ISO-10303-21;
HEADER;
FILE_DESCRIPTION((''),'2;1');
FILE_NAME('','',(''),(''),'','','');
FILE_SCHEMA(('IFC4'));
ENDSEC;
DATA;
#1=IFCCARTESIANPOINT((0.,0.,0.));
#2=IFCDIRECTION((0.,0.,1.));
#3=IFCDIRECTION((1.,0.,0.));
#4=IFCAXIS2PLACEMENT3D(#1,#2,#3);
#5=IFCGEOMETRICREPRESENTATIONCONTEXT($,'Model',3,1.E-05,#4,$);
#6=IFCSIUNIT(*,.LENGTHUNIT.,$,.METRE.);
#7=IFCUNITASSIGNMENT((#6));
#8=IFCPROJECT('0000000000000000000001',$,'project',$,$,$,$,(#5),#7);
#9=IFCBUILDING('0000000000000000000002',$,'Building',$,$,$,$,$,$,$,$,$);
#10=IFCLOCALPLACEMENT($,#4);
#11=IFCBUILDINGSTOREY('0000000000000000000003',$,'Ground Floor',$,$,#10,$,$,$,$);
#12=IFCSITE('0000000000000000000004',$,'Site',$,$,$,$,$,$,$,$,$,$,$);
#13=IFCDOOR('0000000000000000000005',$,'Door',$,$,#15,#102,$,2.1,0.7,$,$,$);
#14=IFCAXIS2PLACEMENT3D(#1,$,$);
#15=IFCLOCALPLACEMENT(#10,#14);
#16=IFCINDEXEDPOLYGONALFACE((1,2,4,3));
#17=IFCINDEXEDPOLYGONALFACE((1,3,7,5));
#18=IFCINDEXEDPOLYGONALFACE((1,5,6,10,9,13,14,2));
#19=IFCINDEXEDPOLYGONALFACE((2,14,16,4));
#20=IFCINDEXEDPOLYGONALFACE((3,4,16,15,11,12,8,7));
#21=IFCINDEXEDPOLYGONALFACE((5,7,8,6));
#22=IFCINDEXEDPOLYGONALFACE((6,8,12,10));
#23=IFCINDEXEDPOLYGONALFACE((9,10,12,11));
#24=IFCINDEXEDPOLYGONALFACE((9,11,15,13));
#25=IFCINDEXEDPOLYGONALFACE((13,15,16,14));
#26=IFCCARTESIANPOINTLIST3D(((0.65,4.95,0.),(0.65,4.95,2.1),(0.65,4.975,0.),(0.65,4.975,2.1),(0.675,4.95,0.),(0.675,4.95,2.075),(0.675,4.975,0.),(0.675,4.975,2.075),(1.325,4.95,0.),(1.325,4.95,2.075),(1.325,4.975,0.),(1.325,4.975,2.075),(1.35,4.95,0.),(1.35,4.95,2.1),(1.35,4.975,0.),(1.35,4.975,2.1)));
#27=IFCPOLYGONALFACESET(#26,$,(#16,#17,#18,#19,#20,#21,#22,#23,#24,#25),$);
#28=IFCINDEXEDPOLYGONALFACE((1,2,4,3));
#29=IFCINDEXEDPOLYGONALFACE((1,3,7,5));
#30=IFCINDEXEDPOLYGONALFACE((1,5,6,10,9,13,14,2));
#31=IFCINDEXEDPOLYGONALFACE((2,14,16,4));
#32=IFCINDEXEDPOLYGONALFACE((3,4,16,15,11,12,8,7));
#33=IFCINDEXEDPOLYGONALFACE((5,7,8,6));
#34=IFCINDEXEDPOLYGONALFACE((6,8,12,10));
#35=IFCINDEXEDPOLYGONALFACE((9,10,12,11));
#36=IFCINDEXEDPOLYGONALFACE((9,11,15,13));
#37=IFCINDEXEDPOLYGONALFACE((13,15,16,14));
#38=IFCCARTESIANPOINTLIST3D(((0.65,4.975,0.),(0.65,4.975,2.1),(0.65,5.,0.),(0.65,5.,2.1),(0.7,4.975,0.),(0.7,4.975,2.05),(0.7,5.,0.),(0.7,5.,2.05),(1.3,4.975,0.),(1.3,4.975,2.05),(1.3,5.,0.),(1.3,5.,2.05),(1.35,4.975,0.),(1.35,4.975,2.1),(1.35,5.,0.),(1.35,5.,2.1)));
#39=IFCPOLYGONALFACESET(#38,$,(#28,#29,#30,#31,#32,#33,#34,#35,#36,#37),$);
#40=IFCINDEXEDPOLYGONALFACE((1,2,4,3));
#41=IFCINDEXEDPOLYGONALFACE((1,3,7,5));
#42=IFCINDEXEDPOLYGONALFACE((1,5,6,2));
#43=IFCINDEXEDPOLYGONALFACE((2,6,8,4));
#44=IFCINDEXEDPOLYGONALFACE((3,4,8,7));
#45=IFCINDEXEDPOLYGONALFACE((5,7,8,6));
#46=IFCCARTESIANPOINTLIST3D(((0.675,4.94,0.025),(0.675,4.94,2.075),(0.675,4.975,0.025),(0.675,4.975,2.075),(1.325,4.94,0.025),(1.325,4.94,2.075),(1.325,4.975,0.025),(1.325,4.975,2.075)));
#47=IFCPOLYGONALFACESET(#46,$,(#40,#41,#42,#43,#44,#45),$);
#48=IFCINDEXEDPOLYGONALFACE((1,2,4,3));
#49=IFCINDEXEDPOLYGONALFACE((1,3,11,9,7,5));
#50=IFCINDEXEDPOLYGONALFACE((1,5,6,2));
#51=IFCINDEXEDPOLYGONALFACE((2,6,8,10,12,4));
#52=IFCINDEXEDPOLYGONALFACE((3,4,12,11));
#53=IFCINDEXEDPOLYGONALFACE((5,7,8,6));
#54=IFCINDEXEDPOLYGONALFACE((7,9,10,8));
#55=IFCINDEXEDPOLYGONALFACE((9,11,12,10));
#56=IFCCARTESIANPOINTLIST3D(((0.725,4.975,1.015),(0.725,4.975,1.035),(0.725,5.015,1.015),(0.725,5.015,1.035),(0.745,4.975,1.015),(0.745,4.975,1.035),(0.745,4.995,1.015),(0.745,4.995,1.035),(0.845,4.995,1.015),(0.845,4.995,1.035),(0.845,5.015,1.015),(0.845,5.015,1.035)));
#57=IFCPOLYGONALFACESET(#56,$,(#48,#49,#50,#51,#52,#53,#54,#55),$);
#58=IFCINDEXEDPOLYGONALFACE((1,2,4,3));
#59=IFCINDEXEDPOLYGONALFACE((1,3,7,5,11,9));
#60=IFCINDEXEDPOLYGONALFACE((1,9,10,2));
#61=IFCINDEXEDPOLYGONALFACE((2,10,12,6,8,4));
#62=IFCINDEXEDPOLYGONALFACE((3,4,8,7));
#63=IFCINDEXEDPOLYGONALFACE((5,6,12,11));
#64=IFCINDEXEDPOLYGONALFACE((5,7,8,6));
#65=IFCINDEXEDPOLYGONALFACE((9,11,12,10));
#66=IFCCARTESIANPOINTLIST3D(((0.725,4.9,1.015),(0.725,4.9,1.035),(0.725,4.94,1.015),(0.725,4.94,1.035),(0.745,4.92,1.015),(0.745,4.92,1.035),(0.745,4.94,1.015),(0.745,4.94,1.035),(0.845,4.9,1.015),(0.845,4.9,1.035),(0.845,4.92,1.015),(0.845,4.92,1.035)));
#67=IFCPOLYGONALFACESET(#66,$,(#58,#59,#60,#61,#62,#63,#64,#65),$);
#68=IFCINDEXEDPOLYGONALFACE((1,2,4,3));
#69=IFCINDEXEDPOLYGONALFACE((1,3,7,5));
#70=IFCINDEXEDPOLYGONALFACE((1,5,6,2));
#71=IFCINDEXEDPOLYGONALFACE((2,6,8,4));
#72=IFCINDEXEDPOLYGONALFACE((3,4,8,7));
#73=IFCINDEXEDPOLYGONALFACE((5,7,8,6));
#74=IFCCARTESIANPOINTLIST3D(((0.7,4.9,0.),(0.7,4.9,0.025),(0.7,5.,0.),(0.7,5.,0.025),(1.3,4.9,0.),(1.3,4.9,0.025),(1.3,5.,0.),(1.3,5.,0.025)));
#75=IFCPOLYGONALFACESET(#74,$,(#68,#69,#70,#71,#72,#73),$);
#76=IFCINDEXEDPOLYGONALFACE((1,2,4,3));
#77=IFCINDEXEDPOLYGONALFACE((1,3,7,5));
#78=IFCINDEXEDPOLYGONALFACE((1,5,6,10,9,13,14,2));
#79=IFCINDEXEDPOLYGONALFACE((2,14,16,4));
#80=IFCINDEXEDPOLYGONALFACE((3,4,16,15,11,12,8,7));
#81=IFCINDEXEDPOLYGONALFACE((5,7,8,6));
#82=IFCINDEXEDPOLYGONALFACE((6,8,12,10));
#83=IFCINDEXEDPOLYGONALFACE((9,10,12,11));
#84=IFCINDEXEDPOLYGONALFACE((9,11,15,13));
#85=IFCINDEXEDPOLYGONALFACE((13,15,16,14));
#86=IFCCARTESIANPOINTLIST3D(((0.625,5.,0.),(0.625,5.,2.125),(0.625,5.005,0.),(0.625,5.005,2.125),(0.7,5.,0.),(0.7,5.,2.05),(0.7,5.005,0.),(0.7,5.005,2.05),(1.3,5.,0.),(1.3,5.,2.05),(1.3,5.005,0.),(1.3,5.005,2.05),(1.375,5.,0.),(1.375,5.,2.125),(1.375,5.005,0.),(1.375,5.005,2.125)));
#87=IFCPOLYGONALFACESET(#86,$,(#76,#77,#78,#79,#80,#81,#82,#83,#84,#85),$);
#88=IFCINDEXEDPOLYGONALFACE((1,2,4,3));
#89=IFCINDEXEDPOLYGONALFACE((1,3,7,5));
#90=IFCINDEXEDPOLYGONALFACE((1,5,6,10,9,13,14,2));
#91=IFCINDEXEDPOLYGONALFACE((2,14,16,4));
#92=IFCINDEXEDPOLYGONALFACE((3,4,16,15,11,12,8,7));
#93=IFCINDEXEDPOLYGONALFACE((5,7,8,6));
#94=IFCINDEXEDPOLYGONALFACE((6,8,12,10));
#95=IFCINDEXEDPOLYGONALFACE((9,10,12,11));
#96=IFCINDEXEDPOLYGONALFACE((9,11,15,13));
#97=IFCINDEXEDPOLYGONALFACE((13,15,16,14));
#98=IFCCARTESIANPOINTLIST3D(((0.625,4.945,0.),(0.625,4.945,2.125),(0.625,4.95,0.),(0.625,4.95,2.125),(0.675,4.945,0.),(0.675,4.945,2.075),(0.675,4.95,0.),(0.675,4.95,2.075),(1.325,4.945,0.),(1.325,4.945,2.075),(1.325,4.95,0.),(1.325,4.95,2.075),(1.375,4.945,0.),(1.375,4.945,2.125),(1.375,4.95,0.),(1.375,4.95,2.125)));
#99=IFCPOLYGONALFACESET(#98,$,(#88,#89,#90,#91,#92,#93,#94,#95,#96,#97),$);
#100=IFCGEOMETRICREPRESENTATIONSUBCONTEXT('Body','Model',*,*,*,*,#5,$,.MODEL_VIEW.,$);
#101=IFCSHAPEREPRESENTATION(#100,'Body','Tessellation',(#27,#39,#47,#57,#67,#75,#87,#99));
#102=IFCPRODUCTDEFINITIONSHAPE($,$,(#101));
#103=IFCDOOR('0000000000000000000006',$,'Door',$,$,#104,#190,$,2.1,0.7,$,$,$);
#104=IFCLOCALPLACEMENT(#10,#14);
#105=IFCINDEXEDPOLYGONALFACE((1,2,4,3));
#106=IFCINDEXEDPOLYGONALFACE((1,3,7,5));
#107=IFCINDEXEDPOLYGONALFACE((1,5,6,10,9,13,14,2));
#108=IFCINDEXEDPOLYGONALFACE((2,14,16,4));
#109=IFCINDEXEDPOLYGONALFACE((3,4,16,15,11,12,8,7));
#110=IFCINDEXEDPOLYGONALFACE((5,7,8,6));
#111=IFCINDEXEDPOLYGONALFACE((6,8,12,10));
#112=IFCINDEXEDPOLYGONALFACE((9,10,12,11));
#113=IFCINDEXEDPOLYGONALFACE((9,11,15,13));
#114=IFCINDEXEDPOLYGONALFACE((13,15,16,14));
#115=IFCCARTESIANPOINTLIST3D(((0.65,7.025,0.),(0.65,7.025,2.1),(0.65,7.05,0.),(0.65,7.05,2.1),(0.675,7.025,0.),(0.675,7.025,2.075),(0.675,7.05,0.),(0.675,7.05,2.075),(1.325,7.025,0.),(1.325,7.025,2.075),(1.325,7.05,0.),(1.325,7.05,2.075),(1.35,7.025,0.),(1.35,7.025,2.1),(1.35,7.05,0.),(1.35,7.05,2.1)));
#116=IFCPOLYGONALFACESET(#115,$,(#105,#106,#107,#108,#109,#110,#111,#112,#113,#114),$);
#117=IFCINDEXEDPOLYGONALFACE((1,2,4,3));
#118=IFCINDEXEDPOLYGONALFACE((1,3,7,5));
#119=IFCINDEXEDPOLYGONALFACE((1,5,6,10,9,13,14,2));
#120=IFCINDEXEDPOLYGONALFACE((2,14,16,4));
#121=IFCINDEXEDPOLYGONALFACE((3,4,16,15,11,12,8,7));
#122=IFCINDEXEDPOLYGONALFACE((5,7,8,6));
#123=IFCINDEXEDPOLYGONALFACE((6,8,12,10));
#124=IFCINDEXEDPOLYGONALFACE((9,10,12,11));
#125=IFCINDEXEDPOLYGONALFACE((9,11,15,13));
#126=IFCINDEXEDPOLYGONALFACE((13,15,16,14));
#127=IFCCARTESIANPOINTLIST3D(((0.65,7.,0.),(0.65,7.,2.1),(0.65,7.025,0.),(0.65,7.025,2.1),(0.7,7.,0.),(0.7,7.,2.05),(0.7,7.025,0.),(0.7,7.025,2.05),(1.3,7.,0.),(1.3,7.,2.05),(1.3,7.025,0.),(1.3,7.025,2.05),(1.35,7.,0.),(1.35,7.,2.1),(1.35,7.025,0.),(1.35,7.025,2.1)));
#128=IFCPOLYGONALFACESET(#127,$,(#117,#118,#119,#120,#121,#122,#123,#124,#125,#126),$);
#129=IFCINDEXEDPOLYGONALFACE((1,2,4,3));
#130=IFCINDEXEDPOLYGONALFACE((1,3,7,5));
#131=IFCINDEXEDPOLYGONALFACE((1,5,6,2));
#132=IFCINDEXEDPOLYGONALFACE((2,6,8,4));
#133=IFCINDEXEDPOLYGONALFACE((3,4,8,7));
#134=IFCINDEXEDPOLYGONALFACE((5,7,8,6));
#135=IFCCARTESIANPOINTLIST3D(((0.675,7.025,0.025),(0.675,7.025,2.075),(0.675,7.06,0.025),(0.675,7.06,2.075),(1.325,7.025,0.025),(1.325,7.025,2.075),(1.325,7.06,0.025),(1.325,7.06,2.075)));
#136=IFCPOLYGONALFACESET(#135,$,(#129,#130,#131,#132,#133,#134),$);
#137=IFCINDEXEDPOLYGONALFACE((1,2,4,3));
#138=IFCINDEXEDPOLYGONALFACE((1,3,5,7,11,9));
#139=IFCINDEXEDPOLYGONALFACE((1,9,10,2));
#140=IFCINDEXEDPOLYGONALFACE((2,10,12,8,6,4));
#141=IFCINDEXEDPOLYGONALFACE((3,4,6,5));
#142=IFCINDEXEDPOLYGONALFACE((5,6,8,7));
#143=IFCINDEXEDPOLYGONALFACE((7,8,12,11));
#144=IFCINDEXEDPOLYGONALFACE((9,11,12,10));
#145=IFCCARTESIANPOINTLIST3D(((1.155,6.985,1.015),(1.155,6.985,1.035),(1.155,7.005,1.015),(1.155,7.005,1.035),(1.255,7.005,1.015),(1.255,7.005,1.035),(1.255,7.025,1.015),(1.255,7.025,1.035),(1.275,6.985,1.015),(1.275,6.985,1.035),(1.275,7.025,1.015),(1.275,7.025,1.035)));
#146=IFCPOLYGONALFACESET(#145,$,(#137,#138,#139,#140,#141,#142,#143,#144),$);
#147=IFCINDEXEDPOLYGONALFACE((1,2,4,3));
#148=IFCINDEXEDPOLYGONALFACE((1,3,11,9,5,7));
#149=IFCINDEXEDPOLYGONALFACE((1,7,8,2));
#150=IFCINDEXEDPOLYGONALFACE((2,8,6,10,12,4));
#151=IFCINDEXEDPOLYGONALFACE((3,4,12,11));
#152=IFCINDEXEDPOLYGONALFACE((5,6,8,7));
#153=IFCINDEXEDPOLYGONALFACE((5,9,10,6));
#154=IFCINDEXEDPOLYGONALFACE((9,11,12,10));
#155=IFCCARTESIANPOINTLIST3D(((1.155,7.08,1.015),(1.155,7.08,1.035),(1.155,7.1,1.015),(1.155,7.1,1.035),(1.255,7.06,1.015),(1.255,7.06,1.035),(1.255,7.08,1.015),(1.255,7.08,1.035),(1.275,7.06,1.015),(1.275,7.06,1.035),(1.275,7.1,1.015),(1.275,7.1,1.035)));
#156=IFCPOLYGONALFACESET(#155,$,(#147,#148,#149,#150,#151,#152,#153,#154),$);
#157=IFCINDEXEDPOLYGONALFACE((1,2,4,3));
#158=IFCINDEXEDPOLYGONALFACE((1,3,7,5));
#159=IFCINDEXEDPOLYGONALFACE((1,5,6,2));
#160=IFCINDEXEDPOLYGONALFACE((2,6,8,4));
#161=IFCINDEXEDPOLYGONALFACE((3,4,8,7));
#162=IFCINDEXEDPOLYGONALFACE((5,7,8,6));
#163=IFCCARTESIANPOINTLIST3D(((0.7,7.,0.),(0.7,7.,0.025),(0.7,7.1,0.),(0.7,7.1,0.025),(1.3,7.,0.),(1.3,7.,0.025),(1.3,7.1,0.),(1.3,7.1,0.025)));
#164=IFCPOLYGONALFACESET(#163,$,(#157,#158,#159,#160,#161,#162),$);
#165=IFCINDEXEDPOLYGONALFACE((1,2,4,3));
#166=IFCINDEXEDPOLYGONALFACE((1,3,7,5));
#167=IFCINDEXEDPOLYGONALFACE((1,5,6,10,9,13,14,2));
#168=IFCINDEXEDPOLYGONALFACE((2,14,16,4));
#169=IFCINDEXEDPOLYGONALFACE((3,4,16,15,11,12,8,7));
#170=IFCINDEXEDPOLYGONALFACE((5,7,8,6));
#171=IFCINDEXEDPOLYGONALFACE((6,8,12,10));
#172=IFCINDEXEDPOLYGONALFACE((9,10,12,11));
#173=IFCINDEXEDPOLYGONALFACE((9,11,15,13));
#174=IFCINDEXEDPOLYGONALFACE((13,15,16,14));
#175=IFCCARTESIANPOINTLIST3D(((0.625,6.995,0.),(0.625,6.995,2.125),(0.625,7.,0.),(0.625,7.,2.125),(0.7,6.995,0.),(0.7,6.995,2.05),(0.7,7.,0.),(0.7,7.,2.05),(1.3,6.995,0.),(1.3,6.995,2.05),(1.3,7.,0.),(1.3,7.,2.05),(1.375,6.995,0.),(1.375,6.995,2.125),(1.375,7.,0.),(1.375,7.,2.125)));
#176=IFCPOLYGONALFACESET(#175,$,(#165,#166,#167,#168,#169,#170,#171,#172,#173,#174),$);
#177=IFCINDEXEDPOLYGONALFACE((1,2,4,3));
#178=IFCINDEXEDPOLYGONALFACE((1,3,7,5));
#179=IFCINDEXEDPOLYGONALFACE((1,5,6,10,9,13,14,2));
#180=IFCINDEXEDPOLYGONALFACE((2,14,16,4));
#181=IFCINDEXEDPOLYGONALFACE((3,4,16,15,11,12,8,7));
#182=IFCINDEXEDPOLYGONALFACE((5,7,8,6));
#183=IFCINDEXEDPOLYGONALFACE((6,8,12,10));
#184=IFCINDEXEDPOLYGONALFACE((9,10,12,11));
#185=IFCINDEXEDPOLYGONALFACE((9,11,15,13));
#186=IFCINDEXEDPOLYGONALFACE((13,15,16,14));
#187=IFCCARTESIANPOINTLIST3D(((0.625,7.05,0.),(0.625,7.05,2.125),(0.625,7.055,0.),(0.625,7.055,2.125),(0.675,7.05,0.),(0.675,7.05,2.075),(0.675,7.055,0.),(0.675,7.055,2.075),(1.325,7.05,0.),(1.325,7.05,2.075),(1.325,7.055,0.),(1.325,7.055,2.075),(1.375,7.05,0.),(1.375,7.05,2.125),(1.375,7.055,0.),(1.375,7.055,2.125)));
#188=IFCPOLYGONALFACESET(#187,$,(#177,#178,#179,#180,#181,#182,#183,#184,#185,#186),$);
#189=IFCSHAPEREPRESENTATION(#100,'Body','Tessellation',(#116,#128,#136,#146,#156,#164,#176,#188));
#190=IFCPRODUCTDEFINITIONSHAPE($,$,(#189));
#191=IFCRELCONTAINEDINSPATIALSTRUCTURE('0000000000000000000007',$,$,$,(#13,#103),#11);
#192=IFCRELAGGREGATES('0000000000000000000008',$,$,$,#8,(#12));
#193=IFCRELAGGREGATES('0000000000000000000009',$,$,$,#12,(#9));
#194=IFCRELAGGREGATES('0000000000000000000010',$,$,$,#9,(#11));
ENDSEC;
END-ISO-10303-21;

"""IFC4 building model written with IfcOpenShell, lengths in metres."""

from ifc_helpers import new_model, si_unit, frame, origin_with_axes, place, context, subcontext, project, spatial, line, indexed_curve, outline, extrude, element, save


model = new_model("IFC4")

# Units and contexts
model_context = context("Model", 3, precision=1e-05, world=origin_with_axes())
body_context = subcontext(model_context, "Body", "Model", "MODEL_VIEW")
ifc_project = project(units=[si_unit("LENGTHUNIT", "METRE")], contexts=[model_context])

# Site, building, storey
site = spatial("IfcSite", under=ifc_project, Name="Site")
building = spatial("IfcBuilding", under=site, Name="Building")
storey_placement = place(None, origin_with_axes())
storey = spatial("IfcBuildingStorey", under=building, at=storey_placement, Name="Ground Floor")

# Doors
door_1_placement = place(storey_placement, frame((1.35, 5.0, 0.0), z_axis=(0.0, 0.0, 1.0), x_axis=(-1.0, 0.0, 0.0)))
element("IfcDoor", 1, at=door_1_placement, inside=storey, Name="Door", OverallHeight=2.1, OverallWidth=0.7, context=body_context, shape_type="SweptSolid", body=[
    extrude(outline(indexed_curve([(0.0, 0.0), (0.0, 2.1), (0.7, 2.1), (0.7, 0.0), (0.675, 0.0), (0.675, 2.075), (0.025, 2.075), (0.025, 0.0)], segments=[line(1, 2, 3, 4, 5, 6, 7, 8, 1)])), frame((0.0, 0.025, 0.0), z_axis=(0.0, -1.0, 0.0), x_axis=(1.0, 0.0, 0.0)), (0.0, 0.0, -1.0), 0.025),
    extrude(outline(indexed_curve([(0.0, 0.0), (0.0, 2.1), (0.7, 2.1), (0.7, 0.0), (0.65, 0.0), (0.65, 2.05), (0.05, 2.05), (0.05, 0.0)], segments=[line(1, 2, 3, 4, 5, 6, 7, 8, 1)])), frame((0.0, 0.0, 0.0), z_axis=(0.0, -1.0, 0.0), x_axis=(1.0, 0.0, 0.0)), (0.0, 0.0, -1.0), 0.025),
    extrude(outline(indexed_curve([(0.0, 0.0), (0.65, 0.0), (0.65, 0.035), (0.0, 0.035)], segments=[line(1, 2, 3, 4, 1)])), frame((0.025, 0.025, 0.025), z_axis=(0.0, 0.0, 1.0), x_axis=(1.0, 0.0, 0.0)), (0.0, 0.0, 1.0), 2.05),
    extrude(outline(indexed_curve([(0.0, 0.0), (0.0, -0.04), (-0.12, -0.04), (-0.12, -0.02), (-0.02, -0.02), (-0.02, 0.0)], segments=[line(1, 2, 3, 4, 5, 6, 1)])), frame((0.625, 0.025, 1.015), z_axis=(0.0, 0.0, 1.0), x_axis=(1.0, 0.0, 0.0)), (0.0, 0.0, 1.0), 0.02),
    extrude(outline(indexed_curve([(0.0, 0.0), (0.0, 0.04), (-0.12, 0.04), (-0.12, 0.02), (-0.02, 0.02), (-0.02, 0.0)], segments=[line(1, 2, 3, 4, 5, 6, 1)])), frame((0.625, 0.06, 1.015), z_axis=(0.0, 0.0, 1.0), x_axis=(1.0, 0.0, 0.0)), (0.0, 0.0, 1.0), 0.02),
    extrude(outline(indexed_curve([(0.0, 0.0), (0.6, 0.0), (0.6, 0.1), (0.0, 0.1)], segments=[line(1, 2, 3, 4, 1)])), frame((0.05, 0.0, 0.0), z_axis=(0.0, 0.0, 1.0), x_axis=(1.0, 0.0, 0.0)), (0.0, 0.0, 1.0), 0.025),
    extrude(outline(indexed_curve([(0.0, 0.0), (0.0, 2.125), (0.75, 2.125), (0.75, 0.0), (0.675, 0.0), (0.675, 2.05), (0.075, 2.05), (0.075, 0.0)], segments=[line(1, 2, 3, 4, 5, 6, 7, 8, 1)])), frame((-0.025, -0.005, 0.0), z_axis=(0.0, -1.0, 0.0), x_axis=(1.0, 0.0, 0.0)), (0.0, 0.0, -1.0), 0.005),
    extrude(outline(indexed_curve([(0.0, 0.0), (0.0, 2.125), (0.75, 2.125), (0.75, 0.0), (0.7, 0.0), (0.7, 2.075), (0.05, 2.075), (0.05, 0.0)], segments=[line(1, 2, 3, 4, 5, 6, 7, 8, 1)])), frame((-0.025, 0.05, 0.0), z_axis=(0.0, -1.0, 0.0), x_axis=(1.0, 0.0, 0.0)), (0.0, 0.0, -1.0), 0.005),
])
door_2_placement = place(storey_placement, frame((0.65, 7.0, 0.0), z_axis=(0.0, 0.0, 1.0), x_axis=(1.0, 0.0, 0.0)))
element("IfcDoor", 2, at=door_2_placement, inside=storey, Name="Door", OverallHeight=2.1, OverallWidth=0.7, context=body_context, shape_type="SweptSolid", body=[
    extrude(outline(indexed_curve([(0.0, 0.0), (0.0, 2.1), (0.7, 2.1), (0.7, 0.0), (0.675, 0.0), (0.675, 2.075), (0.025, 2.075), (0.025, 0.0)], segments=[line(1, 2, 3, 4, 5, 6, 7, 8, 1)])), frame((0.0, 0.025, 0.0), z_axis=(0.0, -1.0, 0.0), x_axis=(1.0, 0.0, 0.0)), (0.0, 0.0, -1.0), 0.025),
    extrude(outline(indexed_curve([(0.0, 0.0), (0.0, 2.1), (0.7, 2.1), (0.7, 0.0), (0.65, 0.0), (0.65, 2.05), (0.05, 2.05), (0.05, 0.0)], segments=[line(1, 2, 3, 4, 5, 6, 7, 8, 1)])), frame((0.0, 0.0, 0.0), z_axis=(0.0, -1.0, 0.0), x_axis=(1.0, 0.0, 0.0)), (0.0, 0.0, -1.0), 0.025),
    extrude(outline(indexed_curve([(0.0, 0.0), (0.65, 0.0), (0.65, 0.035), (0.0, 0.035)], segments=[line(1, 2, 3, 4, 1)])), frame((0.025, 0.025, 0.025), z_axis=(0.0, 0.0, 1.0), x_axis=(1.0, 0.0, 0.0)), (0.0, 0.0, 1.0), 2.05),
    extrude(outline(indexed_curve([(0.0, 0.0), (0.0, -0.04), (-0.12, -0.04), (-0.12, -0.02), (-0.02, -0.02), (-0.02, 0.0)], segments=[line(1, 2, 3, 4, 5, 6, 1)])), frame((0.625, 0.025, 1.015), z_axis=(0.0, 0.0, 1.0), x_axis=(1.0, 0.0, 0.0)), (0.0, 0.0, 1.0), 0.02),
    extrude(outline(indexed_curve([(0.0, 0.0), (0.0, 0.04), (-0.12, 0.04), (-0.12, 0.02), (-0.02, 0.02), (-0.02, 0.0)], segments=[line(1, 2, 3, 4, 5, 6, 1)])), frame((0.625, 0.06, 1.015), z_axis=(0.0, 0.0, 1.0), x_axis=(1.0, 0.0, 0.0)), (0.0, 0.0, 1.0), 0.02),
    extrude(outline(indexed_curve([(0.0, 0.0), (0.6, 0.0), (0.6, 0.1), (0.0, 0.1)], segments=[line(1, 2, 3, 4, 1)])), frame((0.05, 0.0, 0.0), z_axis=(0.0, 0.0, 1.0), x_axis=(1.0, 0.0, 0.0)), (0.0, 0.0, 1.0), 0.025),
    extrude(outline(indexed_curve([(0.0, 0.0), (0.0, 2.125), (0.75, 2.125), (0.75, 0.0), (0.675, 0.0), (0.675, 2.05), (0.075, 2.05), (0.075, 0.0)], segments=[line(1, 2, 3, 4, 5, 6, 7, 8, 1)])), frame((-0.025, -0.005, 0.0), z_axis=(0.0, -1.0, 0.0), x_axis=(1.0, 0.0, 0.0)), (0.0, 0.0, -1.0), 0.005),
    extrude(outline(indexed_curve([(0.0, 0.0), (0.0, 2.125), (0.75, 2.125), (0.75, 0.0), (0.7, 0.0), (0.7, 2.075), (0.05, 2.075), (0.05, 0.0)], segments=[line(1, 2, 3, 4, 5, 6, 7, 8, 1)])), frame((-0.025, 0.05, 0.0), z_axis=(0.0, -1.0, 0.0), x_axis=(1.0, 0.0, 0.0)), (0.0, 0.0, -1.0), 0.005),
])

save(model, "model.ifc")
